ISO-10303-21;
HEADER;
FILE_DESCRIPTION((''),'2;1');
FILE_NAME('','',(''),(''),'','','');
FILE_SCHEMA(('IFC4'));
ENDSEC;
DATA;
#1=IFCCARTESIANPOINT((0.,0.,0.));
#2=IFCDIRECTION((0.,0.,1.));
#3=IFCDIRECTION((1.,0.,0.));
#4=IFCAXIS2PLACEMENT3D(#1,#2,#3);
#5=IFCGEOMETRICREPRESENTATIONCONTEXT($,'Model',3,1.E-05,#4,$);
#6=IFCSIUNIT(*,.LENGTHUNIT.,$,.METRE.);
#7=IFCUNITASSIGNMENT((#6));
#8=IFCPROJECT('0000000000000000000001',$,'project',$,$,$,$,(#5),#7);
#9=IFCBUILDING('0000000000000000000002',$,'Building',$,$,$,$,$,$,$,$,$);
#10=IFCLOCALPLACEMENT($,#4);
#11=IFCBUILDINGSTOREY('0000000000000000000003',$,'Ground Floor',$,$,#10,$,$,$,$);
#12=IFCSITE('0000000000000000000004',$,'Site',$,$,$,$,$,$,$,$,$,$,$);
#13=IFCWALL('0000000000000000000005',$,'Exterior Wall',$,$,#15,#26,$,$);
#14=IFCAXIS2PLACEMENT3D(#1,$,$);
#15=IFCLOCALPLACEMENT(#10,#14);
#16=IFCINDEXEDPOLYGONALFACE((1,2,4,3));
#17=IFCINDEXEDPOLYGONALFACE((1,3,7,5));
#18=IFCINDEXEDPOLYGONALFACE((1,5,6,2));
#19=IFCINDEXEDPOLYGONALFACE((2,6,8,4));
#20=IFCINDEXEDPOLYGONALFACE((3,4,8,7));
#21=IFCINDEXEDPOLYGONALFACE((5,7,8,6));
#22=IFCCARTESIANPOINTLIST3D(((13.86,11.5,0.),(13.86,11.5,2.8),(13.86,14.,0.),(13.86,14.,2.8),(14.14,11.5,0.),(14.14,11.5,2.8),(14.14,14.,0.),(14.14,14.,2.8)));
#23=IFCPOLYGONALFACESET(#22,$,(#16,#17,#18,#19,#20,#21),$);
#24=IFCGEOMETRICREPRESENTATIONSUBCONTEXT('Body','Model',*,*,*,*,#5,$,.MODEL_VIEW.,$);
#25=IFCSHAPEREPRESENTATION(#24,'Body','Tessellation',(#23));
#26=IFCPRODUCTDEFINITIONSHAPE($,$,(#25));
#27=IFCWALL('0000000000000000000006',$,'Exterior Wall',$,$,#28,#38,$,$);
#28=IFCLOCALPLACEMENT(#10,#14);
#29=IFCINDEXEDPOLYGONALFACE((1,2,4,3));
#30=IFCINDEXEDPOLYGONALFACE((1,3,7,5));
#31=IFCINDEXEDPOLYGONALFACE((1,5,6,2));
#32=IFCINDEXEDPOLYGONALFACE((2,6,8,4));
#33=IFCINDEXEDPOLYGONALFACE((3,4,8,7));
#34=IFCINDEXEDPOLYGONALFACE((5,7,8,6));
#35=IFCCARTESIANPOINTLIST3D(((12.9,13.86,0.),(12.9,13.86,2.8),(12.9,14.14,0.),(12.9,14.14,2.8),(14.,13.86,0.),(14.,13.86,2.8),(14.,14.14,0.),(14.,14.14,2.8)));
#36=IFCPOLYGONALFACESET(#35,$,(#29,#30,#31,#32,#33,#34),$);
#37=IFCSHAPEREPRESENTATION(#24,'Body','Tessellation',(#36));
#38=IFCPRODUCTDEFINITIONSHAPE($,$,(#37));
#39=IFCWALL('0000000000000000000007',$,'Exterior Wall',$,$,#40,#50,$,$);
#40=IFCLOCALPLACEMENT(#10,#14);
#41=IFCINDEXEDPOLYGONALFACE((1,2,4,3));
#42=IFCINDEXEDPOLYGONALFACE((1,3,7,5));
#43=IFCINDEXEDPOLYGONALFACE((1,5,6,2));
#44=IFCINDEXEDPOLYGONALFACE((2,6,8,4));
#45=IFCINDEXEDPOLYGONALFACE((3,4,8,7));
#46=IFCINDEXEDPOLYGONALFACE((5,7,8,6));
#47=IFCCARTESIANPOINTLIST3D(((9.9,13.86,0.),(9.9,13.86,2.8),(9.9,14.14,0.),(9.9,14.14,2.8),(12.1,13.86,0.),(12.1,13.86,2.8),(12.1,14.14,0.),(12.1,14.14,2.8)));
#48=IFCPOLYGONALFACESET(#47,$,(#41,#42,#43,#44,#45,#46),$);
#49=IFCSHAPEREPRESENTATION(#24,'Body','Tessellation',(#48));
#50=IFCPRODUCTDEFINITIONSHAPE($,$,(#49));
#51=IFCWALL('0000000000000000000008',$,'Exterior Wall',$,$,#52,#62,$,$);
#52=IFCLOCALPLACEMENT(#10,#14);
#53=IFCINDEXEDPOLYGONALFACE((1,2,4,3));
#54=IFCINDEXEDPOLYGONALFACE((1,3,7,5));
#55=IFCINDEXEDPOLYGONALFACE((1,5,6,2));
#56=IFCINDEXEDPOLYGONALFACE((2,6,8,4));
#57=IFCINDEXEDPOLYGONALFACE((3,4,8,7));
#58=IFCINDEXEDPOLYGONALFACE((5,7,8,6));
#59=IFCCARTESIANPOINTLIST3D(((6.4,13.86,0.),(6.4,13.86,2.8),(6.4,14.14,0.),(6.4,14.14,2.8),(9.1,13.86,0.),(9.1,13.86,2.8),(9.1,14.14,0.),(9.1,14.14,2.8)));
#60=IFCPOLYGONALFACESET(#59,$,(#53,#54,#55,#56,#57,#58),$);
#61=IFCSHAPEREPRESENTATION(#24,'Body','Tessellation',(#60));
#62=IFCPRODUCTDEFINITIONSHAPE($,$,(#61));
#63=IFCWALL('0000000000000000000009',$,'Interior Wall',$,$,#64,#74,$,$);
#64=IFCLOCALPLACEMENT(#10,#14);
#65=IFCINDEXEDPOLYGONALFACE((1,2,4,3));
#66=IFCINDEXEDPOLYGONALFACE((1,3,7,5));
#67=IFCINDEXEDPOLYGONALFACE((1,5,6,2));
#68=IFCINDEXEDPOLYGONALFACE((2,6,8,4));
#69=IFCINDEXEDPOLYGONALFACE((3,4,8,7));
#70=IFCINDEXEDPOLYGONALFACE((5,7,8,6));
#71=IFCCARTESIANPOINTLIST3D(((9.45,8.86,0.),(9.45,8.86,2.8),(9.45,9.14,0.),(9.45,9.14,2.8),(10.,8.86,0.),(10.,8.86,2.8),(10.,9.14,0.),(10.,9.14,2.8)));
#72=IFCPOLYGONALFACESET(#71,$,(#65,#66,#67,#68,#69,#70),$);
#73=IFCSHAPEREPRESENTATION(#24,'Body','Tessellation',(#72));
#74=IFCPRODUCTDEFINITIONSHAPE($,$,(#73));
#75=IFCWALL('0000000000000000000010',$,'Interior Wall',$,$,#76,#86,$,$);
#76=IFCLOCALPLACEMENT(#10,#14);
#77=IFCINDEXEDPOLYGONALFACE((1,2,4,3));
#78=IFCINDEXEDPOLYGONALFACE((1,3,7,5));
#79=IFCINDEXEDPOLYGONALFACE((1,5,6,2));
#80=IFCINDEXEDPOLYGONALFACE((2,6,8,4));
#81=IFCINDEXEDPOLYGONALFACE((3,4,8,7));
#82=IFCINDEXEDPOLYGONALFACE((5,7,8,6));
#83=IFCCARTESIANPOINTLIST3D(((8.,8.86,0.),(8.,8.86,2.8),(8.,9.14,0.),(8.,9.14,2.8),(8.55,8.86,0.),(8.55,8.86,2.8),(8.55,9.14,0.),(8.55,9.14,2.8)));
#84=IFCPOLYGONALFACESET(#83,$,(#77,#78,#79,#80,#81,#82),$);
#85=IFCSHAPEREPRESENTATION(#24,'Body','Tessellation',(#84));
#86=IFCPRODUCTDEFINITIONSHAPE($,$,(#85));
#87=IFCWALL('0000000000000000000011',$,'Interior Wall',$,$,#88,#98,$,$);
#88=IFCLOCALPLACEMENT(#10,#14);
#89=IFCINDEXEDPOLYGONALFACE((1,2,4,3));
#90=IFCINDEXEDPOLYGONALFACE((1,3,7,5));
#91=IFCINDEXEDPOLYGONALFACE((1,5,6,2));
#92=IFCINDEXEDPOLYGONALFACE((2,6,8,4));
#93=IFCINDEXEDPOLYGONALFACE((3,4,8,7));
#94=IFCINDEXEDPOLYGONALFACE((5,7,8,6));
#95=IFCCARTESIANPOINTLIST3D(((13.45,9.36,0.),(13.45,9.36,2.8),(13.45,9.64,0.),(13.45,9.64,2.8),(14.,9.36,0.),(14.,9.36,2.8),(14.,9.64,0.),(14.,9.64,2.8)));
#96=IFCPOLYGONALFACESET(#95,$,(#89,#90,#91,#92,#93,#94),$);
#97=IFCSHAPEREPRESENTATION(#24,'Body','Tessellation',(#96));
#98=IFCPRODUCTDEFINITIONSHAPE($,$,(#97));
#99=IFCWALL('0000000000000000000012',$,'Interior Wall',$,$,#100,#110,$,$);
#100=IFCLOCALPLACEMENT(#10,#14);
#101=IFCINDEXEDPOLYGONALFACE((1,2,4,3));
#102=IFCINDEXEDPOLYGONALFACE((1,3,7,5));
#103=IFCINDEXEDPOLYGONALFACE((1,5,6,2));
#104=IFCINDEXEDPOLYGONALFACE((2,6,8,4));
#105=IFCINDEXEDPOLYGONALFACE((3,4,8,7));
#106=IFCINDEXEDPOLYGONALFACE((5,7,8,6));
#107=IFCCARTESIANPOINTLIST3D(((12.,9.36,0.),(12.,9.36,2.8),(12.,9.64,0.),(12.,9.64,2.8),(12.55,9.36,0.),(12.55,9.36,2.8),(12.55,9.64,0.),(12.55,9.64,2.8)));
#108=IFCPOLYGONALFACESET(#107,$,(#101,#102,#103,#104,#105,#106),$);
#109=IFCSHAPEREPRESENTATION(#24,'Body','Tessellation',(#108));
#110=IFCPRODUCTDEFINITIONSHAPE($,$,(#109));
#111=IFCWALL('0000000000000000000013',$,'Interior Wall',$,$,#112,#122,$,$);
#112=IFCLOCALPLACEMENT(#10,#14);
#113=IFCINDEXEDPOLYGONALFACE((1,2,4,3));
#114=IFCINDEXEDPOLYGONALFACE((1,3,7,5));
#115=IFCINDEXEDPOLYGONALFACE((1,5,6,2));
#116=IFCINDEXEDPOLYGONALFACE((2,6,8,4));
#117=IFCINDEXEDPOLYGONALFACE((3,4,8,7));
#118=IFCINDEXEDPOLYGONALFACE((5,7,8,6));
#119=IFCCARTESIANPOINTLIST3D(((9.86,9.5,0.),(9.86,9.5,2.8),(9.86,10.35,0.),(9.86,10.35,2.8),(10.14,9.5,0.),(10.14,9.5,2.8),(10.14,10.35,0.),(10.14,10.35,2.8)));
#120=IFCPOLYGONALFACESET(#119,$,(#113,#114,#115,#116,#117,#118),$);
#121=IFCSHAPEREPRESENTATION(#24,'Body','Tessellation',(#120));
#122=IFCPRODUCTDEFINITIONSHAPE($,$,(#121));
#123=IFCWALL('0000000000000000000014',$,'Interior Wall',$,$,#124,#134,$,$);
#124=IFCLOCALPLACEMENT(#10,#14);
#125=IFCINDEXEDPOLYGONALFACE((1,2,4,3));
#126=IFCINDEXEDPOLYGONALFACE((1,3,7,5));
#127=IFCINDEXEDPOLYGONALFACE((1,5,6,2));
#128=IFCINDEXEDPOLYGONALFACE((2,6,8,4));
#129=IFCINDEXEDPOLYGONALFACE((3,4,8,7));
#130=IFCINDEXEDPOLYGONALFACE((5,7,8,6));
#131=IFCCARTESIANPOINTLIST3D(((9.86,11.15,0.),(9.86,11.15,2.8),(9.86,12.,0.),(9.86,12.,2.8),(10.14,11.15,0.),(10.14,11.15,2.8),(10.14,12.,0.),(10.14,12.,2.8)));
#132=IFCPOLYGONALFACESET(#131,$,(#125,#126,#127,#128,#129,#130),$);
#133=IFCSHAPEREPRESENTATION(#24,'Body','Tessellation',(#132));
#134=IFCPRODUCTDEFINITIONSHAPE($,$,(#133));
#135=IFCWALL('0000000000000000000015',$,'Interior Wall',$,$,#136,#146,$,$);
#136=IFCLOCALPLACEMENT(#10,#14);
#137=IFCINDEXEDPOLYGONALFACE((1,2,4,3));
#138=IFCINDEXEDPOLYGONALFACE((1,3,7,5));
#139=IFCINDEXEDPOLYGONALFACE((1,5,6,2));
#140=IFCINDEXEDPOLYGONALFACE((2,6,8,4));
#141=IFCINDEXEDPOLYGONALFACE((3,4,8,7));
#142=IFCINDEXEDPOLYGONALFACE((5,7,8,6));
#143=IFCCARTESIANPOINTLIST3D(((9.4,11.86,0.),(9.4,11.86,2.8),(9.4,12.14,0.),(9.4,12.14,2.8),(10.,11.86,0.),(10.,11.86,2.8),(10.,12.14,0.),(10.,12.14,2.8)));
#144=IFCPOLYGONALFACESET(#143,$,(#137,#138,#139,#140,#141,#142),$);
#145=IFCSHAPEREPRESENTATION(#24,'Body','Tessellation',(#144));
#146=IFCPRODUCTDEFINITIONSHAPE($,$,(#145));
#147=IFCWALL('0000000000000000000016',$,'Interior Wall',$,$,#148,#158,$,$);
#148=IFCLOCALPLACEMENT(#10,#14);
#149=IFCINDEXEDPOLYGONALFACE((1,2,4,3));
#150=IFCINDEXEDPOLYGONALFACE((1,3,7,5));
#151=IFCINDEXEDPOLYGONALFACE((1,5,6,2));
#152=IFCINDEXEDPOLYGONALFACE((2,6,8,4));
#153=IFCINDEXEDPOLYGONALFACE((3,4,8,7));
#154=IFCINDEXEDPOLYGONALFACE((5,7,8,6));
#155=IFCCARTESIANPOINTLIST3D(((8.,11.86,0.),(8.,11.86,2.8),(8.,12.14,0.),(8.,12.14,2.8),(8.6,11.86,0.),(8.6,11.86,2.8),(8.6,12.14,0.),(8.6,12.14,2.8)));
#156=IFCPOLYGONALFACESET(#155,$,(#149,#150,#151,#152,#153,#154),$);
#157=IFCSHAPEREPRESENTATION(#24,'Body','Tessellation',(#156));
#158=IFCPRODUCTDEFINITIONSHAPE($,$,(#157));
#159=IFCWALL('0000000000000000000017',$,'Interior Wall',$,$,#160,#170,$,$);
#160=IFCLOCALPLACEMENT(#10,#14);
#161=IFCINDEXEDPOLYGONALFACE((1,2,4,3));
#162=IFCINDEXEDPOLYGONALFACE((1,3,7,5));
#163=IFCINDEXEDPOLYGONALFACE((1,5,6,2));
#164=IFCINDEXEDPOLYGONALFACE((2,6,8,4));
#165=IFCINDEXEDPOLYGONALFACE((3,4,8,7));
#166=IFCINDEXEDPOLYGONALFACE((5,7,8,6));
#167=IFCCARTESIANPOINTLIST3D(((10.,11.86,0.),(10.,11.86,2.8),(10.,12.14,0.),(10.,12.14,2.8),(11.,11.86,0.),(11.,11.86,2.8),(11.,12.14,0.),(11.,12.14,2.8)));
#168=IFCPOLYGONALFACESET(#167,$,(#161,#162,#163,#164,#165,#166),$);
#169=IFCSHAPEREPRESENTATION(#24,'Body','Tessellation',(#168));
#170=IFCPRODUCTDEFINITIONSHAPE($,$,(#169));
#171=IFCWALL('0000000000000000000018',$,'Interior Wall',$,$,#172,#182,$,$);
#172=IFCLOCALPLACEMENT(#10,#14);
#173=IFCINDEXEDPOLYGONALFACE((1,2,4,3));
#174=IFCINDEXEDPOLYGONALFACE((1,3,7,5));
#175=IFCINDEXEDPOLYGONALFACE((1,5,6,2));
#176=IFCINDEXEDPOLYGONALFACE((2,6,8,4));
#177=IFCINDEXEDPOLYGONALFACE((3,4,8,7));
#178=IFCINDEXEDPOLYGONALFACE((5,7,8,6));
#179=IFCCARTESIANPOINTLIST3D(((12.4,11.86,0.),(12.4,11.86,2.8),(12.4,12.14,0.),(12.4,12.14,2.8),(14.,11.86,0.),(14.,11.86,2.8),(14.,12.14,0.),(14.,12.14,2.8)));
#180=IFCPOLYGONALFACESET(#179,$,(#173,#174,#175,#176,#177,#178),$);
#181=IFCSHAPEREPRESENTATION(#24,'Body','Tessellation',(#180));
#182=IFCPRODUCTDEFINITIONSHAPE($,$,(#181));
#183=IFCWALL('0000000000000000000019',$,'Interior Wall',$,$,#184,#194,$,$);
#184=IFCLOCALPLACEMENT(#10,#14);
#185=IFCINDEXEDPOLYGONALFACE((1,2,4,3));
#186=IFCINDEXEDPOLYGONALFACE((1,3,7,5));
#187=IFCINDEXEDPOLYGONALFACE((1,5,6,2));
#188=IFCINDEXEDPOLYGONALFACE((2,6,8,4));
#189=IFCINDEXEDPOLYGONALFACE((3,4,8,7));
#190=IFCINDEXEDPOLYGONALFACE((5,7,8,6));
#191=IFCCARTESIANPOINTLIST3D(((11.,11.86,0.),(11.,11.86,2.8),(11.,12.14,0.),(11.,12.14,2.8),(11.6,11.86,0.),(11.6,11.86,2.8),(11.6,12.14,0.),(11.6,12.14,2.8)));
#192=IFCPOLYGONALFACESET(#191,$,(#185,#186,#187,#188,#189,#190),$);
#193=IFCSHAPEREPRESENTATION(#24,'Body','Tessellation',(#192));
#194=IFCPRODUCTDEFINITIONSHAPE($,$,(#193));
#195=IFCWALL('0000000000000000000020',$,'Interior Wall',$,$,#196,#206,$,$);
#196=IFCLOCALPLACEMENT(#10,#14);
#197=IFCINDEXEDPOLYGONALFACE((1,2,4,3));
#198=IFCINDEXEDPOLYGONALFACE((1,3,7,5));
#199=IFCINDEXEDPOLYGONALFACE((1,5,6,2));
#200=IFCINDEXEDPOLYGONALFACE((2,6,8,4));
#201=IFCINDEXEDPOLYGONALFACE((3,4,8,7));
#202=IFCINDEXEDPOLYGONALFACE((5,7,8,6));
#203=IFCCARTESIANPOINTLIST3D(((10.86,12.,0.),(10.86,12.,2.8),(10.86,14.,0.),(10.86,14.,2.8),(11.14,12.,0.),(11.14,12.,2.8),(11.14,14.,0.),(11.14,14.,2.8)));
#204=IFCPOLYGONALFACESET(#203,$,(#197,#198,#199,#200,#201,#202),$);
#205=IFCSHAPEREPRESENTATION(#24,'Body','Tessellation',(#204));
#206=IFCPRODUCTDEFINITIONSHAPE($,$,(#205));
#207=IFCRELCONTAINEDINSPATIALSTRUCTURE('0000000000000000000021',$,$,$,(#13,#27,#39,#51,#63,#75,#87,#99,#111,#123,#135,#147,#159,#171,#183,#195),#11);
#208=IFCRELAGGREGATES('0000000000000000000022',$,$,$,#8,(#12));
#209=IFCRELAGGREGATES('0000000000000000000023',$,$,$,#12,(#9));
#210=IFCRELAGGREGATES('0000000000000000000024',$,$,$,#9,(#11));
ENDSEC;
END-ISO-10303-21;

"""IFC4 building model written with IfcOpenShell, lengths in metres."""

from ifc_helpers import new_model, si_unit, frame, origin_with_axes, place, context, subcontext, project, spatial, indexed_curve, outline, extrude, element, save


model = new_model("IFC4")

# Units and contexts
model_context = context("Model", 3, precision=1e-05, world=origin_with_axes())
body_context = subcontext(model_context, "Body", "Model", "MODEL_VIEW")
ifc_project = project(units=[si_unit("LENGTHUNIT", "METRE")], contexts=[model_context])

# Site, building, storey
site = spatial("IfcSite", under=ifc_project, Name="Site")
building = spatial("IfcBuilding", under=site, Name="Building")
storey_placement = place(None, origin_with_axes())
storey = spatial("IfcBuildingStorey", under=building, at=storey_placement, Name="Ground Floor")

# Walls
wall_1_placement = place(storey_placement, frame((14.0, 11.5, 0.0), z_axis=(0.0, 0.0, 1.0), x_axis=(0.0, 1.0, 0.0)))
element("IfcWall", 1, at=wall_1_placement, inside=storey, Name="Exterior Wall", context=body_context, shape_type="SweptSolid", body=[
    extrude(outline(indexed_curve([(0.0, 0.0), (0.0, 0.28), (2.5, 0.28), (2.5, 0.0), (0.0, 0.0)], self_intersect=False)), frame((0.0, -0.14, 0.0), z_axis=(0.0, 0.0, 1.0), x_axis=(1.0, 0.0, 0.0)), (0.0, 0.0, 1.0), 2.8),
])
wall_2_placement = place(storey_placement, frame((14.0, 14.0, 0.0), z_axis=(0.0, 0.0, 1.0), x_axis=(-1.0, 0.0, 0.0)))
element("IfcWall", 2, at=wall_2_placement, inside=storey, Name="Exterior Wall", context=body_context, shape_type="SweptSolid", body=[
    extrude(outline(indexed_curve([(0.0, 0.0), (0.0, 0.28), (1.1, 0.28), (1.1, 0.0), (0.0, 0.0)], self_intersect=False)), frame((0.0, -0.14, 0.0), z_axis=(0.0, 0.0, 1.0), x_axis=(1.0, 0.0, 0.0)), (0.0, 0.0, 1.0), 2.8),
])
wall_3_placement = place(storey_placement, frame((12.1, 14.0, 0.0), z_axis=(0.0, 0.0, 1.0), x_axis=(-1.0, 0.0, 0.0)))
element("IfcWall", 3, at=wall_3_placement, inside=storey, Name="Exterior Wall", context=body_context, shape_type="SweptSolid", body=[
    extrude(outline(indexed_curve([(0.0, 0.0), (0.0, 0.28), (2.2, 0.28), (2.2, 0.0), (0.0, 0.0)], self_intersect=False)), frame((0.0, -0.14, 0.0), z_axis=(0.0, 0.0, 1.0), x_axis=(1.0, 0.0, 0.0)), (0.0, 0.0, 1.0), 2.8),
])
wall_4_placement = place(storey_placement, frame((9.1, 14.0, 0.0), z_axis=(0.0, 0.0, 1.0), x_axis=(-1.0, 0.0, 0.0)))
element("IfcWall", 4, at=wall_4_placement, inside=storey, Name="Exterior Wall", context=body_context, shape_type="SweptSolid", body=[
    extrude(outline(indexed_curve([(0.0, 0.0), (0.0, 0.28), (2.7, 0.28), (2.7, 0.0), (0.0, 0.0)], self_intersect=False)), frame((0.0, -0.14, 0.0), z_axis=(0.0, 0.0, 1.0), x_axis=(1.0, 0.0, 0.0)), (0.0, 0.0, 1.0), 2.8),
])
for number, where, z_axis, x_axis, name in (
    (5, (10.0, 9.0, 0.0), (0.0, 0.0, 1.0), (-1.0, 0.0, 0.0), "Interior Wall"),
    (6, (8.55, 9.0, 0.0), (0.0, 0.0, 1.0), (-1.0, 0.0, 0.0), "Interior Wall"),
    (7, (14.0, 9.5, 0.0), (0.0, 0.0, 1.0), (-1.0, 0.0, 0.0), "Interior Wall"),
    (8, (12.55, 9.5, 0.0), (0.0, 0.0, 1.0), (-1.0, 0.0, 0.0), "Interior Wall"),
):
    element("IfcWall", number, at=place(storey_placement, frame(where, z_axis=z_axis, x_axis=x_axis)), inside=storey, Name=name, context=body_context, shape_type="SweptSolid", body=[
        extrude(outline(indexed_curve([(0.0, 0.0), (0.0, 0.28), (0.55, 0.28), (0.55, 0.0), (0.0, 0.0)], self_intersect=False)), frame((0.0, -0.14, 0.0), z_axis=(0.0, 0.0, 1.0), x_axis=(1.0, 0.0, 0.0)), (0.0, 0.0, 1.0), 2.8),
    ])
for number, where, z_axis, x_axis, name in (
    (9, (10.0, 9.5, 0.0), (0.0, 0.0, 1.0), (0.0, 1.0, 0.0), "Interior Wall"),
    (10, (10.0, 11.15, 0.0), (0.0, 0.0, 1.0), (0.0, 1.0, 0.0), "Interior Wall"),
):
    element("IfcWall", number, at=place(storey_placement, frame(where, z_axis=z_axis, x_axis=x_axis)), inside=storey, Name=name, context=body_context, shape_type="SweptSolid", body=[
        extrude(outline(indexed_curve([(0.0, 0.0), (0.0, 0.28), (0.85, 0.28), (0.85, 0.0), (0.0, 0.0)], self_intersect=False)), frame((0.0, -0.14, 0.0), z_axis=(0.0, 0.0, 1.0), x_axis=(1.0, 0.0, 0.0)), (0.0, 0.0, 1.0), 2.8),
    ])
for number, where, z_axis, x_axis, name in (
    (11, (10.0, 12.0, 0.0), (0.0, 0.0, 1.0), (-1.0, 0.0, 0.0), "Interior Wall"),
    (12, (8.6, 12.0, 0.0), (0.0, 0.0, 1.0), (-1.0, 0.0, 0.0), "Interior Wall"),
):
    element("IfcWall", number, at=place(storey_placement, frame(where, z_axis=z_axis, x_axis=x_axis)), inside=storey, Name=name, context=body_context, shape_type="SweptSolid", body=[
        extrude(outline(indexed_curve([(0.0, 0.0), (0.0, 0.28), (0.6, 0.28), (0.6, 0.0), (0.0, 0.0)], self_intersect=False)), frame((0.0, -0.14, 0.0), z_axis=(0.0, 0.0, 1.0), x_axis=(1.0, 0.0, 0.0)), (0.0, 0.0, 1.0), 2.8),
    ])
wall_5_placement = place(storey_placement, frame((11.0, 12.0, 0.0), z_axis=(0.0, 0.0, 1.0), x_axis=(-1.0, 0.0, 0.0)))
element("IfcWall", 13, at=wall_5_placement, inside=storey, Name="Interior Wall", context=body_context, shape_type="SweptSolid", body=[
    extrude(outline(indexed_curve([(0.0, 0.0), (0.0, 0.28), (1.0, 0.28), (1.0, 0.0), (0.0, 0.0)], self_intersect=False)), frame((0.0, -0.14, 0.0), z_axis=(0.0, 0.0, 1.0), x_axis=(1.0, 0.0, 0.0)), (0.0, 0.0, 1.0), 2.8),
])
wall_6_placement = place(storey_placement, frame((14.0, 12.0, 0.0), z_axis=(0.0, 0.0, 1.0), x_axis=(-1.0, 0.0, 0.0)))
element("IfcWall", 14, at=wall_6_placement, inside=storey, Name="Interior Wall", context=body_context, shape_type="SweptSolid", body=[
    extrude(outline(indexed_curve([(0.0, 0.0), (0.0, 0.28), (1.6, 0.28), (1.6, 0.0), (0.0, 0.0)], self_intersect=False)), frame((0.0, -0.14, 0.0), z_axis=(0.0, 0.0, 1.0), x_axis=(1.0, 0.0, 0.0)), (0.0, 0.0, 1.0), 2.8),
])
wall_7_placement = place(storey_placement, frame((11.6, 12.0, 0.0), z_axis=(0.0, 0.0, 1.0), x_axis=(-1.0, 0.0, 0.0)))
element("IfcWall", 15, at=wall_7_placement, inside=storey, Name="Interior Wall", context=body_context, shape_type="SweptSolid", body=[
    extrude(outline(indexed_curve([(0.0, 0.0), (0.0, 0.28), (0.6, 0.28), (0.6, 0.0), (0.0, 0.0)], self_intersect=False)), frame((0.0, -0.14, 0.0), z_axis=(0.0, 0.0, 1.0), x_axis=(1.0, 0.0, 0.0)), (0.0, 0.0, 1.0), 2.8),
])
wall_8_placement = place(storey_placement, frame((11.0, 12.0, 0.0), z_axis=(0.0, 0.0, 1.0), x_axis=(0.0, 1.0, 0.0)))
element("IfcWall", 16, at=wall_8_placement, inside=storey, Name="Interior Wall", context=body_context, shape_type="SweptSolid", body=[
    extrude(outline(indexed_curve([(0.0, 0.0), (0.0, 0.28), (2.0, 0.28), (2.0, 0.0), (0.0, 0.0)], self_intersect=False)), frame((0.0, -0.14, 0.0), z_axis=(0.0, 0.0, 1.0), x_axis=(1.0, 0.0, 0.0)), (0.0, 0.0, 1.0), 2.8),
])

save(model, "model.ifc")
